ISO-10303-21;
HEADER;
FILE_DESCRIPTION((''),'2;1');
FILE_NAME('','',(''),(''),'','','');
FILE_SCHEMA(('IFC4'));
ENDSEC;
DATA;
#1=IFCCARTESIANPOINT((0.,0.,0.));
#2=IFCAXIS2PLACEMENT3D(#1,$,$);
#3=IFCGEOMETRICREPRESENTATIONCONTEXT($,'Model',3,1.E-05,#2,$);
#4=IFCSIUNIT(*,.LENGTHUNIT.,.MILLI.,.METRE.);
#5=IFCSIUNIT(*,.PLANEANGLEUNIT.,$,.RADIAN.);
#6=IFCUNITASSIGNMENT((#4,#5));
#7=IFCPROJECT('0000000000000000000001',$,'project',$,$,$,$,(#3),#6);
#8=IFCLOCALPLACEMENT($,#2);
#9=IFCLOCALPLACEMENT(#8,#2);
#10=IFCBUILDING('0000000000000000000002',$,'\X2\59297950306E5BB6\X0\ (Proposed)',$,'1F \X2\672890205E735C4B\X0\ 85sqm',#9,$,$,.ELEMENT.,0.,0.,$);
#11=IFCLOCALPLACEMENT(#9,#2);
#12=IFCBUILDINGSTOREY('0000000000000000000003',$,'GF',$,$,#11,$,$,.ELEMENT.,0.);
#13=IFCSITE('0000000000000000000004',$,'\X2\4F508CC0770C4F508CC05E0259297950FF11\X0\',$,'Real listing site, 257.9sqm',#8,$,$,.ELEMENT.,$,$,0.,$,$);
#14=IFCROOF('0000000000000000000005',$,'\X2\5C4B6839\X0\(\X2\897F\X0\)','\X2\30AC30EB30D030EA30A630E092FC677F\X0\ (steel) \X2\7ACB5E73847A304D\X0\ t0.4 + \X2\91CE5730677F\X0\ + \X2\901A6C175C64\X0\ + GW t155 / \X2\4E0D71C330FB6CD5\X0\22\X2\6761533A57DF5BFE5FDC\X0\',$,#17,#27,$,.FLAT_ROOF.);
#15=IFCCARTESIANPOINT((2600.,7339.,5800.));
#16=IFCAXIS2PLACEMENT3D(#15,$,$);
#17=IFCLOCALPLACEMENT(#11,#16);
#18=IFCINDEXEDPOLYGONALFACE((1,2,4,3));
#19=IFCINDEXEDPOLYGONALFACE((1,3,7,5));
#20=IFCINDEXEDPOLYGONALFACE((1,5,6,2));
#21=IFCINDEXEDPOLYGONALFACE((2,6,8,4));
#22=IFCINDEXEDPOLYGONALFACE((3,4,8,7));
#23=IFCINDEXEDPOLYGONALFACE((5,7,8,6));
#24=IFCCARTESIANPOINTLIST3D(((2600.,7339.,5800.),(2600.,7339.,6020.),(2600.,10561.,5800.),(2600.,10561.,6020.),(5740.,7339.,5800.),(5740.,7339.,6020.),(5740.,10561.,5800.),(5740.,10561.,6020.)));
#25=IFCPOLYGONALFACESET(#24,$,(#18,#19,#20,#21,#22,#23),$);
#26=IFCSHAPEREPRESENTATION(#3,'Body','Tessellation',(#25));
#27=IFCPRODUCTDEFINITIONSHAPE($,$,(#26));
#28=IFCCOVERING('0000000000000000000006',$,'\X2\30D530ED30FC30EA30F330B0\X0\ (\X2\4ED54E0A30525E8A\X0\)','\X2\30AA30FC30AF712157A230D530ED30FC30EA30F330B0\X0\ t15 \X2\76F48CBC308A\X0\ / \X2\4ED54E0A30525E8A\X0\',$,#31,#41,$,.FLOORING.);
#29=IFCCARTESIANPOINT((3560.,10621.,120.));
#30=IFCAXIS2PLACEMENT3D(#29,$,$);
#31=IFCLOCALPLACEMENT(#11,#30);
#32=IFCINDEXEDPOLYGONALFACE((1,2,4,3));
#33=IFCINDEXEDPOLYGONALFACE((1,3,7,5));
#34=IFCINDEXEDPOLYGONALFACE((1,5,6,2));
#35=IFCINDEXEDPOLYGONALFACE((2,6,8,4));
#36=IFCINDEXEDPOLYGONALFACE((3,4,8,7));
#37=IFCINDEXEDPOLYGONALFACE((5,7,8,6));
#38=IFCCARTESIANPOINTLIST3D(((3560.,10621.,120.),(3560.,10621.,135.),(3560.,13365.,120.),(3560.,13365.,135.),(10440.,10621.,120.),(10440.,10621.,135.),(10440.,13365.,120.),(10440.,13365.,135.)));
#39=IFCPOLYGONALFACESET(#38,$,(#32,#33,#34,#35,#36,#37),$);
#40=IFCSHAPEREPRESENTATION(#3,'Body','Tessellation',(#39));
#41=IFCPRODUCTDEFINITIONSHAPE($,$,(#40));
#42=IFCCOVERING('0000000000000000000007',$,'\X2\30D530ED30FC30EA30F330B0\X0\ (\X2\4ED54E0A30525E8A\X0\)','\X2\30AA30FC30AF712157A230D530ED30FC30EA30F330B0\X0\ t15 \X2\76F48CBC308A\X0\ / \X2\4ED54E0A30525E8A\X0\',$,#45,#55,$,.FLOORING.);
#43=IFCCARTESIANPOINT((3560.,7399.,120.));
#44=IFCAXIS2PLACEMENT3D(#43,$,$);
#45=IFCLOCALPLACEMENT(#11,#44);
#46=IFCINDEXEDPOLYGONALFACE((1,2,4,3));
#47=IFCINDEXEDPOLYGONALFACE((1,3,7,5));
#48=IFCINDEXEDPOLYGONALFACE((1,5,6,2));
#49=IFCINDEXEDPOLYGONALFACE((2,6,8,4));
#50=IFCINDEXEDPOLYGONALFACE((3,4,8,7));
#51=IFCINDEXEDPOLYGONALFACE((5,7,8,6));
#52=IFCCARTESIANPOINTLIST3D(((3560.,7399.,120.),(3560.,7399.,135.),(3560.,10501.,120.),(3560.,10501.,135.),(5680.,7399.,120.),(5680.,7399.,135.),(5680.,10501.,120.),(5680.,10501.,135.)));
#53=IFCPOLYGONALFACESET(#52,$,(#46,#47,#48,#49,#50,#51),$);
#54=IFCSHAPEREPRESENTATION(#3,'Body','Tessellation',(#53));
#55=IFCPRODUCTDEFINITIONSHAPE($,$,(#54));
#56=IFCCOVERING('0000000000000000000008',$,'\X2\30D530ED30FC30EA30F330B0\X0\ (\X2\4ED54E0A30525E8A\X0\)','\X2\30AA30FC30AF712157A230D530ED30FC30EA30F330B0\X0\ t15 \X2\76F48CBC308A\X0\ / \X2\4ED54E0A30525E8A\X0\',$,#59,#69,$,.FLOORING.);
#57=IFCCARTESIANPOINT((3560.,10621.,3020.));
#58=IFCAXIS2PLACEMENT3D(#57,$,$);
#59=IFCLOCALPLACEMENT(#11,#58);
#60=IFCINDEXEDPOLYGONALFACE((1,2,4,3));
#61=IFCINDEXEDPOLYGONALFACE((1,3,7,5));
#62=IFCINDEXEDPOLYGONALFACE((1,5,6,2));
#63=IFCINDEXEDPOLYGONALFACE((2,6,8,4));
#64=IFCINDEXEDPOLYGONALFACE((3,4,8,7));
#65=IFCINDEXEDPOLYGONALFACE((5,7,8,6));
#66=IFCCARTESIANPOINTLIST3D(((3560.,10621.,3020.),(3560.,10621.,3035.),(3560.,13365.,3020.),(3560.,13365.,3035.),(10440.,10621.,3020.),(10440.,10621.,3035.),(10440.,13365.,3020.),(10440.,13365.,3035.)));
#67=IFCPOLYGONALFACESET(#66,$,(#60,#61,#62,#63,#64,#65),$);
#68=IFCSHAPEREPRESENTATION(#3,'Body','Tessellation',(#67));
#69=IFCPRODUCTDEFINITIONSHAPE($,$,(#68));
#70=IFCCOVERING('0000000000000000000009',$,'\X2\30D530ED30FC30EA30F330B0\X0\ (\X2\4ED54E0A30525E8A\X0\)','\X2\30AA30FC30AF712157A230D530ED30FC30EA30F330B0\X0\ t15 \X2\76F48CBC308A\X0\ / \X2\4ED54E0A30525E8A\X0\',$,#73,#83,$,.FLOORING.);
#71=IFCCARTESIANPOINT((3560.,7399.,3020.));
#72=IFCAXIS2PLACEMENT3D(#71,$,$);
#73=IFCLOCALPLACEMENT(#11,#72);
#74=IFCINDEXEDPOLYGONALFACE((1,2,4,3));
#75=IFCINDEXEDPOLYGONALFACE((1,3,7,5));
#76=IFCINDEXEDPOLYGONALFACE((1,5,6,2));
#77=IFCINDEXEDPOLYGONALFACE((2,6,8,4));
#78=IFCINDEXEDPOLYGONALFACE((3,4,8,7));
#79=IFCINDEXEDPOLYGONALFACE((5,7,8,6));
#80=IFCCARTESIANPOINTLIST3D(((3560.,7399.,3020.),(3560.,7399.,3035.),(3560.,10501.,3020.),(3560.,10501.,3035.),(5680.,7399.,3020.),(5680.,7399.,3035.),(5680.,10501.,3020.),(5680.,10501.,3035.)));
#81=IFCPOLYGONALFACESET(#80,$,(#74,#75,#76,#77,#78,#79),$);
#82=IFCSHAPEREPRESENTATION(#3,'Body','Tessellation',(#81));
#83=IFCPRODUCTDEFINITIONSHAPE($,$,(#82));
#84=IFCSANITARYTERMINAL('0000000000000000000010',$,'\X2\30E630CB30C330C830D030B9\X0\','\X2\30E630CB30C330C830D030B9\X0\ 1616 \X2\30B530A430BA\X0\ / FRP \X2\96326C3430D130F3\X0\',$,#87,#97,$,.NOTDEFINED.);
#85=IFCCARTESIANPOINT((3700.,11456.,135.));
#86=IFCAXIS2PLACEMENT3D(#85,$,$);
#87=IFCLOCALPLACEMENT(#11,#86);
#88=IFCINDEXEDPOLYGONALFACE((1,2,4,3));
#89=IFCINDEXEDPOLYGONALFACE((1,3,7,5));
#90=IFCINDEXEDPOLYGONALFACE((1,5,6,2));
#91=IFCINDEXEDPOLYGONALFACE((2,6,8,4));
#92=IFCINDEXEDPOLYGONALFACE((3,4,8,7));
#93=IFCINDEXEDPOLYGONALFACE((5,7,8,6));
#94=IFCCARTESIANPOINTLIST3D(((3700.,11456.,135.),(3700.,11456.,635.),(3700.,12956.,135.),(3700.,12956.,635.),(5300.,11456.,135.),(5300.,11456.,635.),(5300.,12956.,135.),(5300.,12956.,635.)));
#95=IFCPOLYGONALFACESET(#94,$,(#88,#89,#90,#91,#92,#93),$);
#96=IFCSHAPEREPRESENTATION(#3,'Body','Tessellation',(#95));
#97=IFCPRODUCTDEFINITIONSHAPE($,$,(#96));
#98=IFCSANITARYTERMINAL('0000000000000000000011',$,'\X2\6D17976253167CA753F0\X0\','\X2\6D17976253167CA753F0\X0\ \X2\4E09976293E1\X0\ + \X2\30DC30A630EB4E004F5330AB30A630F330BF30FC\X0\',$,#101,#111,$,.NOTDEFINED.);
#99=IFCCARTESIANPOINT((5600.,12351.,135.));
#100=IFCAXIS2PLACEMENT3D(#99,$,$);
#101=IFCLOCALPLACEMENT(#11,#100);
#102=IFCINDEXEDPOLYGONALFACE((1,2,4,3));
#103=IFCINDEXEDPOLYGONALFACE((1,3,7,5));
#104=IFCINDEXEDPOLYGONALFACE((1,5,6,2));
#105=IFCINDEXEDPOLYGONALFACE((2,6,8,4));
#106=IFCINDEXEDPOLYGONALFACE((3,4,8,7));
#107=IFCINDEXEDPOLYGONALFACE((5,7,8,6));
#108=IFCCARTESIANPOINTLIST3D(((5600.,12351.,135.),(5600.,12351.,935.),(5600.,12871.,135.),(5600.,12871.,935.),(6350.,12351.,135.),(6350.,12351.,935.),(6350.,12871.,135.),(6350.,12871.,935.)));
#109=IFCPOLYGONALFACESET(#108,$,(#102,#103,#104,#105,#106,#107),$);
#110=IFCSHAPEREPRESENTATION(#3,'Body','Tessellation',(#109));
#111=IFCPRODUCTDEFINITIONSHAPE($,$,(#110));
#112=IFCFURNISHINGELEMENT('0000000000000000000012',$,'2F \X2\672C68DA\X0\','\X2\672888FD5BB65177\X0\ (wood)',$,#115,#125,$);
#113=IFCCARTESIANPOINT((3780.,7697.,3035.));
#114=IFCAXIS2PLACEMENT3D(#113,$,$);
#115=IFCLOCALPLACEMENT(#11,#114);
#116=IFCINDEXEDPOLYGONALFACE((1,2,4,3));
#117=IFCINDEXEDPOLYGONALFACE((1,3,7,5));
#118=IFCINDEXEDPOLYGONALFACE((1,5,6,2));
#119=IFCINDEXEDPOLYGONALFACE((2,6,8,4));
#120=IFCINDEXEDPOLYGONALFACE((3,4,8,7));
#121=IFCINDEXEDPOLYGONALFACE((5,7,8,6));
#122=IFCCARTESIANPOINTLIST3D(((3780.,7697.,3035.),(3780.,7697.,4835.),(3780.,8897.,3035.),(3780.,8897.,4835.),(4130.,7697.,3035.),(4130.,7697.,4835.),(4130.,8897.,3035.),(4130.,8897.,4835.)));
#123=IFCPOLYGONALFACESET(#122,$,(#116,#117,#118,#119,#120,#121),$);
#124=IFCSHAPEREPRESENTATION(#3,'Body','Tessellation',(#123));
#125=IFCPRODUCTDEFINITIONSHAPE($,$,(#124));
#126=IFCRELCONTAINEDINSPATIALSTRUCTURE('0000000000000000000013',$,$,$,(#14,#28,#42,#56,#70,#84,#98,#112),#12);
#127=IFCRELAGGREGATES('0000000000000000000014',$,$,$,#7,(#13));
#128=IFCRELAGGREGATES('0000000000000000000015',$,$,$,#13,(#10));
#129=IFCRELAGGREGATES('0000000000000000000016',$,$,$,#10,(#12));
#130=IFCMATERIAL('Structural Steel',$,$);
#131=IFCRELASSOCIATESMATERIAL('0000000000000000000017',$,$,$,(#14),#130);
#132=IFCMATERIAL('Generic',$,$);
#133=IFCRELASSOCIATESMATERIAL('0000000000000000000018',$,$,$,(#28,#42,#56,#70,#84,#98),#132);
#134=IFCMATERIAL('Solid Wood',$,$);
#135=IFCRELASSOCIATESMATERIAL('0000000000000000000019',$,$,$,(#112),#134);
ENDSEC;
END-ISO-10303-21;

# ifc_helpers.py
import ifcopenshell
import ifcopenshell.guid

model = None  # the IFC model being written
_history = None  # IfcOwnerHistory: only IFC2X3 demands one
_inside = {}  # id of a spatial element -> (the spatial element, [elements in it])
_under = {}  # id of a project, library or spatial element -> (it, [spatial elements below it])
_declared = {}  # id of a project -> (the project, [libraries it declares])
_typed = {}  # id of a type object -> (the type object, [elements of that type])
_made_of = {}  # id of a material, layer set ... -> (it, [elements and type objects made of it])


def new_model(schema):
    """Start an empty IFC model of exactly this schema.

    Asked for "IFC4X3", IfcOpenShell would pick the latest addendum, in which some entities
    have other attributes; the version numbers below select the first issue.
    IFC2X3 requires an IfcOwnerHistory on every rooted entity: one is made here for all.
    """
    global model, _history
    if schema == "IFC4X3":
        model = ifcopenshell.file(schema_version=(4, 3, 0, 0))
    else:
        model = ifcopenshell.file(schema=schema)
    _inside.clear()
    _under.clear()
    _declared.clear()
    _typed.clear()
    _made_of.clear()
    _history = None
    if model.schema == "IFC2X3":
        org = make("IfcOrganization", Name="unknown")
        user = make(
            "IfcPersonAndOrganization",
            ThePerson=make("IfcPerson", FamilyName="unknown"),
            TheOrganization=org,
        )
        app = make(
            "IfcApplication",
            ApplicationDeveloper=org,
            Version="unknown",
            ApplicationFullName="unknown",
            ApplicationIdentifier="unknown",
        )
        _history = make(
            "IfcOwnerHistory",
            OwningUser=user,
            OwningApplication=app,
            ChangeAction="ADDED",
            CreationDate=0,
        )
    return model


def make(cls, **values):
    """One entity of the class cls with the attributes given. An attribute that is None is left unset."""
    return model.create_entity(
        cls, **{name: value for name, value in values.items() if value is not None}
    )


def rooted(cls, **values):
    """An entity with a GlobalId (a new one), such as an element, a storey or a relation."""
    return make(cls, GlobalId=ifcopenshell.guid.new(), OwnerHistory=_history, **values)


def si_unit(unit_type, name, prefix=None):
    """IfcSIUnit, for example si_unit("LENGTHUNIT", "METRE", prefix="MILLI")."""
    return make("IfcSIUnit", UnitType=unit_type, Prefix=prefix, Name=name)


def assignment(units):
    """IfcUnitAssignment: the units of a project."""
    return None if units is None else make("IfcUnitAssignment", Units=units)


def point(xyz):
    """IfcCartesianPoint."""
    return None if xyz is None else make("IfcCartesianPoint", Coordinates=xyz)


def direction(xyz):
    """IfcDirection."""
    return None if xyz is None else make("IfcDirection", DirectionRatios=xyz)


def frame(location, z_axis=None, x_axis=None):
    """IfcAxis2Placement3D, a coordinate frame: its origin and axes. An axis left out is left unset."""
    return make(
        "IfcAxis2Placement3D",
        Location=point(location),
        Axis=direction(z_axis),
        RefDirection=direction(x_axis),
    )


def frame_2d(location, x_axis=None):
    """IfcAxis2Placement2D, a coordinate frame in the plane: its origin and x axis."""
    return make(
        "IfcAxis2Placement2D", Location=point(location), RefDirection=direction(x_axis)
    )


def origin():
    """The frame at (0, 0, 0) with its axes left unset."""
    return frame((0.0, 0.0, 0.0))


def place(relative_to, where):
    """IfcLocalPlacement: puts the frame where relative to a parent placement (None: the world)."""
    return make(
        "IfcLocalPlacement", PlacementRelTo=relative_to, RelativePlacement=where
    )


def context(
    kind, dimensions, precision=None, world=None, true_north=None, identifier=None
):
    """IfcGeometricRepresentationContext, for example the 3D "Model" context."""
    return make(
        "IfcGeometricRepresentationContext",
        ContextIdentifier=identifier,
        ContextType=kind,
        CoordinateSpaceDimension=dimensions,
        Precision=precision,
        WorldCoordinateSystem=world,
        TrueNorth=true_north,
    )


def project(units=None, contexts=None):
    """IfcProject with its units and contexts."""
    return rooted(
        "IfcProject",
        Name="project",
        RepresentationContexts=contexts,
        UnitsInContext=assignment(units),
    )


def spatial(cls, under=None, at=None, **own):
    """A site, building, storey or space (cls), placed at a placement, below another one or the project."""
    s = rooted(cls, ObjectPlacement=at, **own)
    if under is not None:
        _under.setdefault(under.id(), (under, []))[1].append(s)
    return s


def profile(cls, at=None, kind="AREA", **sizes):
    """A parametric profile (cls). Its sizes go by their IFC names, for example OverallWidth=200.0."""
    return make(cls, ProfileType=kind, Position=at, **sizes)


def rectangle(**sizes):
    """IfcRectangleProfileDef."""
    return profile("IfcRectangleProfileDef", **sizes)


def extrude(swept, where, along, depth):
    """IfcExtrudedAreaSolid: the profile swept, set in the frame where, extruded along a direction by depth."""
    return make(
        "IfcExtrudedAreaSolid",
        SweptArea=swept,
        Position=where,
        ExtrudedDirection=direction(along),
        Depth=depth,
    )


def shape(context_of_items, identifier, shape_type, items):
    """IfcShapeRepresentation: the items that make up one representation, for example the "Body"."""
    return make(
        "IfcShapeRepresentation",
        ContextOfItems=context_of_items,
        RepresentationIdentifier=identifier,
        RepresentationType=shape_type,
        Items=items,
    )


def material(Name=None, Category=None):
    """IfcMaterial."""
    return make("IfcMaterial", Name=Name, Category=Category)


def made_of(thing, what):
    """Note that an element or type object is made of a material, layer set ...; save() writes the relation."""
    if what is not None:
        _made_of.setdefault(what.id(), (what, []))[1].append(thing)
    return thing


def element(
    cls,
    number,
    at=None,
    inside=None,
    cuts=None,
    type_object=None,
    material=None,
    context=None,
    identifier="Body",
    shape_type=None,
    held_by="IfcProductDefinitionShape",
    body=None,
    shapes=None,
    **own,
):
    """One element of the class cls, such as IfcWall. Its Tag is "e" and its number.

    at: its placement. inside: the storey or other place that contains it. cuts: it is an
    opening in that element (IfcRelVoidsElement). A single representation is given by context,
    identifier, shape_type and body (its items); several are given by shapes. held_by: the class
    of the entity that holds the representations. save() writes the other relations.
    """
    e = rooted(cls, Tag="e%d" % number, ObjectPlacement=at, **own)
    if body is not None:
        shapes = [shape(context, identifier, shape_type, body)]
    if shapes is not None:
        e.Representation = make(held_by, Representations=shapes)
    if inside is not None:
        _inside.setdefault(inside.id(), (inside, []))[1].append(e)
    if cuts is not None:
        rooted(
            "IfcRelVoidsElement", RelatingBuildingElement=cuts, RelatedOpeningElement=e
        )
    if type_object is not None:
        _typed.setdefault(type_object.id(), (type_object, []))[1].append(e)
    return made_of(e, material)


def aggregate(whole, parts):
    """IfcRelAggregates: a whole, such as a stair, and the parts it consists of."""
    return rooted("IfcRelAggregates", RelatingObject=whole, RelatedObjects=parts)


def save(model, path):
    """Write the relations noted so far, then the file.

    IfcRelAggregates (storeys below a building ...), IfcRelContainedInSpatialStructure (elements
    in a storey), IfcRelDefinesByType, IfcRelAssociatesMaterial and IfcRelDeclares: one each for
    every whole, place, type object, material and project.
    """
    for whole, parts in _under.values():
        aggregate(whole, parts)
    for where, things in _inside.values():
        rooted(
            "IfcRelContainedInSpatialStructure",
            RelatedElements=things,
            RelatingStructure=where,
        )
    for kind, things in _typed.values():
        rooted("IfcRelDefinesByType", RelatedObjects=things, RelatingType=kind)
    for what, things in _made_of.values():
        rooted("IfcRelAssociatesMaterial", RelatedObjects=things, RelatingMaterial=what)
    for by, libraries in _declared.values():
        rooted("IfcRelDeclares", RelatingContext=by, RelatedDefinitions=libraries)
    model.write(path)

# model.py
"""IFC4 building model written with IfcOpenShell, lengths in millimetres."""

from ifc_helpers import new_model, si_unit, frame, frame_2d, origin, place, context, project, spatial, rectangle, extrude, material, element, save


model = new_model("IFC4")

# Units and contexts
model_context = context("Model", 3, precision=1e-05, world=origin())
ifc_project = project(units=[si_unit("LENGTHUNIT", "METRE", prefix="MILLI"), si_unit("PLANEANGLEUNIT", "RADIAN")], contexts=[model_context])

# Site, building, storey
site_placement = place(None, origin())
site = spatial("IfcSite", under=ifc_project, at=site_placement, Name="佐賀県佐賀市天祐１", ObjectType="Real listing site, 257.9sqm", CompositionType="ELEMENT", RefElevation=0.0)
building_placement = place(site_placement, origin())
building = spatial("IfcBuilding", under=site, at=building_placement, Name="天祐の家 (Proposed)", ObjectType="1F 木造平屋 85sqm", CompositionType="ELEMENT", ElevationOfRefHeight=0.0, ElevationOfTerrain=0.0)
storey_placement = place(building_placement, origin())
storey = spatial("IfcBuildingStorey", under=building, at=storey_placement, Name="GF", CompositionType="ELEMENT", Elevation=0.0)

# Shared definitions
ifc_material_1 = material(Name="Solid Wood")

# Roof
ifc_material_2 = material(Name="Structural Steel")
roof_placement = place(storey_placement, frame((2600.0, 7339.0, 5800.0)))
element("IfcRoof", 1, at=roof_placement, inside=storey, material=ifc_material_2, Name="屋根(西)", Description="ガルバリウム鋼板 (steel) 立平葺き t0.4 + 野地板 + 通気層 + GW t155 / 不燃・法22条区域対応", PredefinedType="FLAT_ROOF", context=model_context, shape_type="SweptSolid", body=[
    extrude(rectangle(XDim=3140.0, YDim=3222.0, at=frame_2d((1570.0, 1611.0))), frame((2600.0, 7339.0, 5800.0)), (0.0, 0.0, 1.0), 220.0),
])

# Coverings
ifc_material_3 = material(Name="Generic")
covering_1_placement = place(storey_placement, frame((3560.0, 10621.0, 120.0)))
element("IfcCovering", 2, at=covering_1_placement, inside=storey, material=ifc_material_3, Name="フローリング (仕上げ床)", Description="オーク無垢フローリング t15 直貼り / 仕上げ床", PredefinedType="FLOORING", context=model_context, shape_type="SweptSolid", body=[
    extrude(rectangle(XDim=6880.0, YDim=2744.0, at=frame_2d((3440.0, 1372.0))), frame((3560.0, 10621.0, 120.0)), (0.0, 0.0, 1.0), 15.0),
])
covering_2_placement = place(storey_placement, frame((3560.0, 7399.0, 120.0)))
element("IfcCovering", 3, at=covering_2_placement, inside=storey, material=ifc_material_3, Name="フローリング (仕上げ床)", Description="オーク無垢フローリング t15 直貼り / 仕上げ床", PredefinedType="FLOORING", context=model_context, shape_type="SweptSolid", body=[
    extrude(rectangle(XDim=2120.0, YDim=3102.0, at=frame_2d((1060.0, 1551.0))), frame((3560.0, 7399.0, 120.0)), (0.0, 0.0, 1.0), 15.0),
])
covering_3_placement = place(storey_placement, frame((3560.0, 10621.0, 3020.0)))
element("IfcCovering", 4, at=covering_3_placement, inside=storey, material=ifc_material_3, Name="フローリング (仕上げ床)", Description="オーク無垢フローリング t15 直貼り / 仕上げ床", PredefinedType="FLOORING", context=model_context, shape_type="SweptSolid", body=[
    extrude(rectangle(XDim=6880.0, YDim=2744.0, at=frame_2d((3440.0, 1372.0))), frame((3560.0, 10621.0, 3020.0)), (0.0, 0.0, 1.0), 15.0),
])
covering_4_placement = place(storey_placement, frame((3560.0, 7399.0, 3020.0)))
element("IfcCovering", 5, at=covering_4_placement, inside=storey, material=ifc_material_3, Name="フローリング (仕上げ床)", Description="オーク無垢フローリング t15 直貼り / 仕上げ床", PredefinedType="FLOORING", context=model_context, shape_type="SweptSolid", body=[
    extrude(rectangle(XDim=2120.0, YDim=3102.0, at=frame_2d((1060.0, 1551.0))), frame((3560.0, 7399.0, 3020.0)), (0.0, 0.0, 1.0), 15.0),
])

# Sanitary terminals
sanitary_terminal_1_placement = place(storey_placement, frame((3700.0, 11456.0, 135.0)))
element("IfcSanitaryTerminal", 6, at=sanitary_terminal_1_placement, inside=storey, material=ifc_material_3, Name="ユニットバス", Description="ユニットバス 1616 サイズ / FRP 防水パン", PredefinedType="NOTDEFINED", context=model_context, shape_type="SweptSolid", body=[
    extrude(rectangle(XDim=1600.0, YDim=1500.0, at=frame_2d((800.0, 750.0))), frame((3700.0, 11456.0, 135.0)), (0.0, 0.0, 1.0), 500.0),
])
sanitary_terminal_2_placement = place(storey_placement, frame((5600.0, 12351.0, 135.0)))
element("IfcSanitaryTerminal", 7, at=sanitary_terminal_2_placement, inside=storey, material=ifc_material_3, Name="洗面化粧台", Description="洗面化粧台 三面鏡 + ボウル一体カウンター", PredefinedType="NOTDEFINED", context=model_context, shape_type="SweptSolid", body=[
    extrude(rectangle(XDim=750.0, YDim=520.0, at=frame_2d((375.0, 260.0))), frame((5600.0, 12351.0, 135.0)), (0.0, 0.0, 1.0), 800.0),
])

# Furnishing element
furnishing_placement = place(storey_placement, frame((3780.0, 7697.0, 3035.0)))
element("IfcFurnishingElement", 8, at=furnishing_placement, inside=storey, material=ifc_material_1, Name="2F 本棚", Description="木製家具 (wood)", context=model_context, shape_type="SweptSolid", body=[
    extrude(rectangle(XDim=350.0, YDim=1200.0, at=frame_2d((175.0, 600.0))), frame((3780.0, 7697.0, 3035.0)), (0.0, 0.0, 1.0), 1800.0),
])

save(model, "model.ifc")
